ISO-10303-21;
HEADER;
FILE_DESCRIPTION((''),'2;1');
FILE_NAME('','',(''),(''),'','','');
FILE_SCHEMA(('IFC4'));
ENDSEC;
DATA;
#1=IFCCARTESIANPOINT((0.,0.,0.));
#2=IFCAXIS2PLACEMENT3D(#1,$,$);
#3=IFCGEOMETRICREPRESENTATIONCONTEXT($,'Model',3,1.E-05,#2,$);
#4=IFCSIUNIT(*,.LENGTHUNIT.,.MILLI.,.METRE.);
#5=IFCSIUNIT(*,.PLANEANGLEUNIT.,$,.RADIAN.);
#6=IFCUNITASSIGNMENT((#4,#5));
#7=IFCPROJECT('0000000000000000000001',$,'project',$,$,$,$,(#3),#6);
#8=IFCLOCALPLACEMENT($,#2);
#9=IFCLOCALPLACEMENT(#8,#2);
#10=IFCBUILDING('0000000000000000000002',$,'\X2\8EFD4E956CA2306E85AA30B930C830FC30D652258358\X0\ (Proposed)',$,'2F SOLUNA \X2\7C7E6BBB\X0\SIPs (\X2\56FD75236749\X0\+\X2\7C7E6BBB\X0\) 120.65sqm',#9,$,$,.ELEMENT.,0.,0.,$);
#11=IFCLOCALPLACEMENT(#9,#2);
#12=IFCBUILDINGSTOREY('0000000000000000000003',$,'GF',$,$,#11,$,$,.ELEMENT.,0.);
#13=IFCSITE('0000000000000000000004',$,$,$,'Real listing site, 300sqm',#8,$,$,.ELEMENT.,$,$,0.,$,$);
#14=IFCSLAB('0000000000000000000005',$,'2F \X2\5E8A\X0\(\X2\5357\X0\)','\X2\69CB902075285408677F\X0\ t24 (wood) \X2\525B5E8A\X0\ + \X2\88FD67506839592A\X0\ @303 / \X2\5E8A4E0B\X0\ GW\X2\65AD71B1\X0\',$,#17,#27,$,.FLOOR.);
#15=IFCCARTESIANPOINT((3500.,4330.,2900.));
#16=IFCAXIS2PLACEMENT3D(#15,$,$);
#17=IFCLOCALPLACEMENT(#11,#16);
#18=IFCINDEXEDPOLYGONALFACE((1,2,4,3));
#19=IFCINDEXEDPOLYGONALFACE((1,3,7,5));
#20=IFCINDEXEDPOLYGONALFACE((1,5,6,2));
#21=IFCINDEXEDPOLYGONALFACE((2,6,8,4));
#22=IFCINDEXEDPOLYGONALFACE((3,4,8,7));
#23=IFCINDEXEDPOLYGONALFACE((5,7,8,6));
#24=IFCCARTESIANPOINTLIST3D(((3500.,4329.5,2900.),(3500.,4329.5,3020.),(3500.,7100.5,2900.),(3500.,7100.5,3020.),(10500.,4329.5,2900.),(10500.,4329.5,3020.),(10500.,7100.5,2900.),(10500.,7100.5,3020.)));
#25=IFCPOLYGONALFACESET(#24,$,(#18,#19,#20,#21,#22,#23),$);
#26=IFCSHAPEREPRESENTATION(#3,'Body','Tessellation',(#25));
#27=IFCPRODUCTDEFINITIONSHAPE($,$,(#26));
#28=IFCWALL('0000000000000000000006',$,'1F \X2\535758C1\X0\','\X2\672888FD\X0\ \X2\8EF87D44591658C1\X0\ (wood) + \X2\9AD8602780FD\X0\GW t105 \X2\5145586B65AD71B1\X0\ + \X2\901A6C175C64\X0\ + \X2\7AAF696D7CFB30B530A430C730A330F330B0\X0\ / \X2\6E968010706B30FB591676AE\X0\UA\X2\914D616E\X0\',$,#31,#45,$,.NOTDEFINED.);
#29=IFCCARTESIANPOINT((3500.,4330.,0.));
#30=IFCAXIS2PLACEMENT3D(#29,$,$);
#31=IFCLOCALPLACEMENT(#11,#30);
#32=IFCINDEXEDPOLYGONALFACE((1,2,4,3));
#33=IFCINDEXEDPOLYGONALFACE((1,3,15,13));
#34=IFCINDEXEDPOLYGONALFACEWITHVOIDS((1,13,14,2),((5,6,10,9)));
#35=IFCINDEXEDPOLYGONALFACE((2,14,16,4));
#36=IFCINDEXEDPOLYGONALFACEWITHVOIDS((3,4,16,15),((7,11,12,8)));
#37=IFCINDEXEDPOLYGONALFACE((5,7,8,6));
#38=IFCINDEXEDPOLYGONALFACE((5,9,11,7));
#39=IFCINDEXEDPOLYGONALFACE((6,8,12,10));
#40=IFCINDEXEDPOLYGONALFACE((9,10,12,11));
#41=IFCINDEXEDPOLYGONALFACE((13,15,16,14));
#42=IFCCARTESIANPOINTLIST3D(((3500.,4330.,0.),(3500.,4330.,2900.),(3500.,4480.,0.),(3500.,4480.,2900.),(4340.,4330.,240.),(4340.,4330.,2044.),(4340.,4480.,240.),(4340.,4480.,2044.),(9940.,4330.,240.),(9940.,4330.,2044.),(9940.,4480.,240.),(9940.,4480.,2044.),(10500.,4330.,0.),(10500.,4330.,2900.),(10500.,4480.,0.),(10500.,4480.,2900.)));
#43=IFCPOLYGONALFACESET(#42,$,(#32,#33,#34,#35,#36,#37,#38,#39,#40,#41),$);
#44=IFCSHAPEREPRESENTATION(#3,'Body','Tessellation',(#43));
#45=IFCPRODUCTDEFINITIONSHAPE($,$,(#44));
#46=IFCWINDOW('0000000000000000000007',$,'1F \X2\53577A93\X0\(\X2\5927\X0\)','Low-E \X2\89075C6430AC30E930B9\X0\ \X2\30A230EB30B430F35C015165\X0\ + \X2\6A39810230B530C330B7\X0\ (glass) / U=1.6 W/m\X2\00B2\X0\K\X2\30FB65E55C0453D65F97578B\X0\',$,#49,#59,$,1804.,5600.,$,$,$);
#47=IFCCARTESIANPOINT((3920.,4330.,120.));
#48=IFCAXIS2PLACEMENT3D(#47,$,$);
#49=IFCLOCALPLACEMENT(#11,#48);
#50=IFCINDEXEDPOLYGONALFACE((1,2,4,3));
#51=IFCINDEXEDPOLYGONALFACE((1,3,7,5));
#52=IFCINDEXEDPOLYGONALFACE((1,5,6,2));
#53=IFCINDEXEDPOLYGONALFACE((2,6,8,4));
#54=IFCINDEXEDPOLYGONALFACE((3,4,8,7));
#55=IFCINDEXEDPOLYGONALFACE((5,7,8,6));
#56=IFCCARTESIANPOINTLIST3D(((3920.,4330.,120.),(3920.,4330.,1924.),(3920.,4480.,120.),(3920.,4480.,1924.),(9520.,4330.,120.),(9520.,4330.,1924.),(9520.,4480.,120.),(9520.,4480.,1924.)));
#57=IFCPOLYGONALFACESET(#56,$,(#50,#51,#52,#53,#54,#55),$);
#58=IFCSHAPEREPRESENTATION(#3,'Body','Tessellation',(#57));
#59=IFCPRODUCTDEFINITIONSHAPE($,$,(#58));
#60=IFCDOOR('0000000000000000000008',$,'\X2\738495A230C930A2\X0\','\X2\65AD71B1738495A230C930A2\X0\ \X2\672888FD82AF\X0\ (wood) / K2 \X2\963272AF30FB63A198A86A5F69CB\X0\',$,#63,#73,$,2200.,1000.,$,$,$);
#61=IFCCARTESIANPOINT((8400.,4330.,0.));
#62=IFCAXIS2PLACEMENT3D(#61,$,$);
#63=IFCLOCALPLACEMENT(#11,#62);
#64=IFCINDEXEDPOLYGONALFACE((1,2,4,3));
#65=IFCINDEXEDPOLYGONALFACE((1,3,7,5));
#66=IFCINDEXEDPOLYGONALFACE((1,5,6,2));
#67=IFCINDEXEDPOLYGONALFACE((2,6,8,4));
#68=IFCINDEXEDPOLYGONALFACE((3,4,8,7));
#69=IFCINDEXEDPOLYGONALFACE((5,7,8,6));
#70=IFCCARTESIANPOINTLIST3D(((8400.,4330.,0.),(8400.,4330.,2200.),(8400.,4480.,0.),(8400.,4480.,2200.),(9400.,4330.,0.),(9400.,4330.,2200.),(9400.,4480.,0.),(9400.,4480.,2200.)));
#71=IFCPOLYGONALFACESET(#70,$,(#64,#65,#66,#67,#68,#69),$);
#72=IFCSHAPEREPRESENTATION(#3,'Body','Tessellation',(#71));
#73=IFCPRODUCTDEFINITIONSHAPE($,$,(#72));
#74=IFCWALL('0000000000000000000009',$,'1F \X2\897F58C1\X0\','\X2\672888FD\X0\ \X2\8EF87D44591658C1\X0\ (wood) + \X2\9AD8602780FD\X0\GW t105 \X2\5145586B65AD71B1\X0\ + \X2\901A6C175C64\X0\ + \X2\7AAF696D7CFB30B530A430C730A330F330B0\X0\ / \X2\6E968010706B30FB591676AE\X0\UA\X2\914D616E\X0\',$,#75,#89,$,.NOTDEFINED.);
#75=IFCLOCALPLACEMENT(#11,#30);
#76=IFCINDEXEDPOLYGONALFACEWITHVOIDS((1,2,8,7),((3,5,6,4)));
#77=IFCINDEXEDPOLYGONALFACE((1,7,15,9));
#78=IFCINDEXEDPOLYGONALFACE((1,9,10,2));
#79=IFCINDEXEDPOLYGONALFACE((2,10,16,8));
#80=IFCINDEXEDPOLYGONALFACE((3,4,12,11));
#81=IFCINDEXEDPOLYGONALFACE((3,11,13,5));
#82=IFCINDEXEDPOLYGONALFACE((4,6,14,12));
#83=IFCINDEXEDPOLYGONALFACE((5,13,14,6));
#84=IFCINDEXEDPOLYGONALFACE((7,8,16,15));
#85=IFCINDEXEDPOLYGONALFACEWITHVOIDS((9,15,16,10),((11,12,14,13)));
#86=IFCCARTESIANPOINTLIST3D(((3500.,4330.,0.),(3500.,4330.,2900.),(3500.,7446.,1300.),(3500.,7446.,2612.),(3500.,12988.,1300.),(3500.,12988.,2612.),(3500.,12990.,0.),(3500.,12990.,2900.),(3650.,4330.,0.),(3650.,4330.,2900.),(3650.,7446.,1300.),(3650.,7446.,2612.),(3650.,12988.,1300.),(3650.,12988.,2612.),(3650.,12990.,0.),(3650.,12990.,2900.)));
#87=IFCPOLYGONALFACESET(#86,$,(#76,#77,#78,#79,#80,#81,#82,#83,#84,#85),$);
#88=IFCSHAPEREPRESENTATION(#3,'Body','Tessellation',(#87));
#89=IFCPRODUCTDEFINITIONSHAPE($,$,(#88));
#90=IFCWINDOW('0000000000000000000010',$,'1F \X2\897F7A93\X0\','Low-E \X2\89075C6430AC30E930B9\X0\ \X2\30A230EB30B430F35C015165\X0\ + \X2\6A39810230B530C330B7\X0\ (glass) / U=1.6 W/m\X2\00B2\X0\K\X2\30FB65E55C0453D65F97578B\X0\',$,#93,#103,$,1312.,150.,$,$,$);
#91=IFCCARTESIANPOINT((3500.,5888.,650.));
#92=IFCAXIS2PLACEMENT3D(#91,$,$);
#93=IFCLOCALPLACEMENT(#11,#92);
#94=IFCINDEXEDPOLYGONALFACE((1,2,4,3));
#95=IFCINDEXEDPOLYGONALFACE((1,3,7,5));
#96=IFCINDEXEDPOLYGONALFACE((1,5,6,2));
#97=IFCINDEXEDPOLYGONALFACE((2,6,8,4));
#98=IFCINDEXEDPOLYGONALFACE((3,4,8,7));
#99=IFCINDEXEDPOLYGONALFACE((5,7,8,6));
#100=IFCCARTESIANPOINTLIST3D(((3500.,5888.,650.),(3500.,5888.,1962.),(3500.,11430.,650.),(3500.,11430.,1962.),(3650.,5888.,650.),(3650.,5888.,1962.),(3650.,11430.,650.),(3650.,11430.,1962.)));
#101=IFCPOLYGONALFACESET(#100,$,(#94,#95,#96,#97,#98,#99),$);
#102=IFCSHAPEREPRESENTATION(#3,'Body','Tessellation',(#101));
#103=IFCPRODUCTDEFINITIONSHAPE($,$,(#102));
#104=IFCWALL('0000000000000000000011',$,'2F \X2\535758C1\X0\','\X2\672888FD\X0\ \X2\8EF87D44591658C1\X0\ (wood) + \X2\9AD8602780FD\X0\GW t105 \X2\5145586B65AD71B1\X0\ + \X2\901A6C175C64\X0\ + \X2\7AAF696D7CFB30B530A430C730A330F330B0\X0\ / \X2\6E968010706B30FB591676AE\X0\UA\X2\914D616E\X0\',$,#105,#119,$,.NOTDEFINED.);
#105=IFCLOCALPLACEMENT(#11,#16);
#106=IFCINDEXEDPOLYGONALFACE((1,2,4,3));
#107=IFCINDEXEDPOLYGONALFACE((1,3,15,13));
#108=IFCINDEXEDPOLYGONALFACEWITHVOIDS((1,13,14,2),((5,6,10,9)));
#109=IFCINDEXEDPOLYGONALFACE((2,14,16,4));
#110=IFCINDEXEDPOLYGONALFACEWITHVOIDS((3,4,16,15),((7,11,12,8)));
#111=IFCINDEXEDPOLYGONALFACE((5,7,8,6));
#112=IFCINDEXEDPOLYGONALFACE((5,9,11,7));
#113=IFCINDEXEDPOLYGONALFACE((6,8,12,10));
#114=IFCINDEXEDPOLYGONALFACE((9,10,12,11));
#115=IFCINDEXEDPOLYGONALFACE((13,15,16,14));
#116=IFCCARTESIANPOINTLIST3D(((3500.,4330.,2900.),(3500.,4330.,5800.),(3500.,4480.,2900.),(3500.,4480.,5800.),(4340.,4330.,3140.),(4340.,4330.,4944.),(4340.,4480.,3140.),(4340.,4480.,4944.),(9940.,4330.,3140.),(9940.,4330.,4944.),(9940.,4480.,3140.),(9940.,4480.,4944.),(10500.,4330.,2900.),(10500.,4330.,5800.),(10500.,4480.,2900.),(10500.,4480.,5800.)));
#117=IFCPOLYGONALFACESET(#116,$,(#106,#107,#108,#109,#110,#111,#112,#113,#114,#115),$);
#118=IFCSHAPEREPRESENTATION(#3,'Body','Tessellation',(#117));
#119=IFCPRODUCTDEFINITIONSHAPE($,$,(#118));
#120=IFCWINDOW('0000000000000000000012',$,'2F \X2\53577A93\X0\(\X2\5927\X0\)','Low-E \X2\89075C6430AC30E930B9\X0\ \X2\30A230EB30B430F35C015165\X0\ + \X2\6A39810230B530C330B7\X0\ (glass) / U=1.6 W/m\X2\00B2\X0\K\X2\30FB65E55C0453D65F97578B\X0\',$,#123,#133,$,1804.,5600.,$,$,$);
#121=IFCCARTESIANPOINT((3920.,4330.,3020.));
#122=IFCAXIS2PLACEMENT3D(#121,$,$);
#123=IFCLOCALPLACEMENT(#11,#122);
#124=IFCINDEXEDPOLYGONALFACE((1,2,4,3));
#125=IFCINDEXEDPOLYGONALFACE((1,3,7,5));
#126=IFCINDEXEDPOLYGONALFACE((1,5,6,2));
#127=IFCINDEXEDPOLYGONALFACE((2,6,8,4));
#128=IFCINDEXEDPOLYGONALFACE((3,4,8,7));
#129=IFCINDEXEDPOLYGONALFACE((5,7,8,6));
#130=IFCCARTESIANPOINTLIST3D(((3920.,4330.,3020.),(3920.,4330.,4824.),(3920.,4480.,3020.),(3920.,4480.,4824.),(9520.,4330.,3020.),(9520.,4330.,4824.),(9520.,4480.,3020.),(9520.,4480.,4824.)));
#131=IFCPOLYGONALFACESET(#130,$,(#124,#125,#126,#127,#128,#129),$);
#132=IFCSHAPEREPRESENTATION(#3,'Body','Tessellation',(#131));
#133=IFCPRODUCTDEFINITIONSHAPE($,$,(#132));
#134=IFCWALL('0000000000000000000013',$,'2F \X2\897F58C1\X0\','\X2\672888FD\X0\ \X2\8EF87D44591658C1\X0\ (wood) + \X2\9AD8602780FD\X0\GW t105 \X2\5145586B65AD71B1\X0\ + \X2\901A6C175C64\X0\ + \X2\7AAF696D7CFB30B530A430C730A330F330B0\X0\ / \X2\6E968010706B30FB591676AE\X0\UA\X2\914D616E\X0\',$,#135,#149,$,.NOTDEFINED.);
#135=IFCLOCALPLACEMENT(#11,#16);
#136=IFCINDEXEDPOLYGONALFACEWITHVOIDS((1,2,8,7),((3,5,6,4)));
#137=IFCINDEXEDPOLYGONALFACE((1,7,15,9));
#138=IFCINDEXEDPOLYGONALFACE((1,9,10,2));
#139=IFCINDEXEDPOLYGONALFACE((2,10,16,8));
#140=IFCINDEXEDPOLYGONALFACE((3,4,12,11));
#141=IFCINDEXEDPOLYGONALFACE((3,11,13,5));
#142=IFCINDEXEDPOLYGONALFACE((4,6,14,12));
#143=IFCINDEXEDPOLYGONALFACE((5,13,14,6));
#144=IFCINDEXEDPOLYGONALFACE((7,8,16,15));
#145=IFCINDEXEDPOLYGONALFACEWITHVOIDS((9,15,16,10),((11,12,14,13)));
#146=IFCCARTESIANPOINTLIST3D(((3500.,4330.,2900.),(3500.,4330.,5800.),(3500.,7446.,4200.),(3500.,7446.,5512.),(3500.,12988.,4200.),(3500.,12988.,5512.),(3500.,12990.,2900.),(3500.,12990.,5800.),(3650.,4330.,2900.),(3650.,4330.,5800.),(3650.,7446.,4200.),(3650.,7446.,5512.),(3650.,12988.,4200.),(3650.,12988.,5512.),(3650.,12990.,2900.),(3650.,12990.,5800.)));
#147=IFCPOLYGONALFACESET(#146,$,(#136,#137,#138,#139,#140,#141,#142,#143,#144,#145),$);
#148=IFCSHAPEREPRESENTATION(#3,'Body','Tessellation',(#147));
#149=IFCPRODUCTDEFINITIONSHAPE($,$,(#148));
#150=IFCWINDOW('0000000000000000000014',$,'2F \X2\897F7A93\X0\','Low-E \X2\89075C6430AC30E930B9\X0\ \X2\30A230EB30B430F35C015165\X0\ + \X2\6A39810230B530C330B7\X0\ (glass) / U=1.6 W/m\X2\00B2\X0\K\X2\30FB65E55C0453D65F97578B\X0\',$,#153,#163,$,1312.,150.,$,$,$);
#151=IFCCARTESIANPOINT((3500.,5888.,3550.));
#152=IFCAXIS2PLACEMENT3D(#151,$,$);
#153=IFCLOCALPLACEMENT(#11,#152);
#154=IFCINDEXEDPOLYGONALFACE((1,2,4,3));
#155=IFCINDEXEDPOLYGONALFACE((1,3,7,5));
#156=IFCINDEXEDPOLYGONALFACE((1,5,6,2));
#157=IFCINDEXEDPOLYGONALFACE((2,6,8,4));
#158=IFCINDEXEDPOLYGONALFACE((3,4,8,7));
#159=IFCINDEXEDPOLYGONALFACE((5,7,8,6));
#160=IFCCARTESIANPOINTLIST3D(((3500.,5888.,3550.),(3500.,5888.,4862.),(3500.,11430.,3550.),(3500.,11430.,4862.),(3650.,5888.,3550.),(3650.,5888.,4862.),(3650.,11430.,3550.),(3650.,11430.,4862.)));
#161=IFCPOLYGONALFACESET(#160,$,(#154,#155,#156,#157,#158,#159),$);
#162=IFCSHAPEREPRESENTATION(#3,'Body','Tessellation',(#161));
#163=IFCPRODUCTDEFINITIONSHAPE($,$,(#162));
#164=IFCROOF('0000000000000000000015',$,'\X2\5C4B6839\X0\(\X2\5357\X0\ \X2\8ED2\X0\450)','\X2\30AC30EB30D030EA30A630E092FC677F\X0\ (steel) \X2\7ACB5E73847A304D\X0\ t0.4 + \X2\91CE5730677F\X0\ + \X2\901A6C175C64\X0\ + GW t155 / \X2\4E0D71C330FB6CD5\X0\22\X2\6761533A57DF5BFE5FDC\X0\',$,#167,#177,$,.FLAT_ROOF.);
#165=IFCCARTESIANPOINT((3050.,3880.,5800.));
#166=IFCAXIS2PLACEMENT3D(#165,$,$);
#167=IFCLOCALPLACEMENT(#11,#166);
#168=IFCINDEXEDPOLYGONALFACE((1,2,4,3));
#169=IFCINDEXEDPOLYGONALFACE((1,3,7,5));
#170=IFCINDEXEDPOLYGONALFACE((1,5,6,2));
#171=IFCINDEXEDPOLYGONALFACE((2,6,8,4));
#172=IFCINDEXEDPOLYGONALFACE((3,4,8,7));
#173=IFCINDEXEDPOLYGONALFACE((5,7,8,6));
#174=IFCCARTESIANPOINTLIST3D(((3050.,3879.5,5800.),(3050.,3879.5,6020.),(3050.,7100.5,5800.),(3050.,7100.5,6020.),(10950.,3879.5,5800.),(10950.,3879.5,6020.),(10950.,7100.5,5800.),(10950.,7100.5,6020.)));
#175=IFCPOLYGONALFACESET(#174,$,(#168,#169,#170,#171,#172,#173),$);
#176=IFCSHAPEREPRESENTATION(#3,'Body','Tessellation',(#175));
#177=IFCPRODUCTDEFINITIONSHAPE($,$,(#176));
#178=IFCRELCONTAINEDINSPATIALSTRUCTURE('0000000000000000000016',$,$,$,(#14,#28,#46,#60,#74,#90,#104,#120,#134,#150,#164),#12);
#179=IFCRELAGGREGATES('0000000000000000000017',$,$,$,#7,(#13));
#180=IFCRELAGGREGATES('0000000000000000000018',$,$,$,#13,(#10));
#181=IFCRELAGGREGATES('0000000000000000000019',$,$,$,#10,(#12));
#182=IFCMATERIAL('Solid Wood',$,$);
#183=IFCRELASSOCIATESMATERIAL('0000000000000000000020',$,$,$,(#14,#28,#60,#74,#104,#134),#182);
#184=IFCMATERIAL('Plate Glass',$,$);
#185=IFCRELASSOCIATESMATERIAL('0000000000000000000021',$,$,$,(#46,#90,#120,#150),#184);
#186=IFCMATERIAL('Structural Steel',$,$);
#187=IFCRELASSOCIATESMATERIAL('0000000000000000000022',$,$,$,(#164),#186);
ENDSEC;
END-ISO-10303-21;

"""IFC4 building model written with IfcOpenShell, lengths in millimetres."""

from ifc_helpers import new_model, si_unit, frame, frame_2d, origin, place, context, project, spatial, rectangle, extrude, material, element, fill, save


model = new_model("IFC4")

# Units and contexts
model_context = context("Model", 3, precision=1e-05, world=origin())
ifc_project = project(units=[si_unit("LENGTHUNIT", "METRE", prefix="MILLI"), si_unit("PLANEANGLEUNIT", "RADIAN")], contexts=[model_context])

# Site, building, storey
site_placement = place(None, origin())
site = spatial("IfcSite", under=ifc_project, at=site_placement, ObjectType="Real listing site, 300sqm", CompositionType="ELEMENT", RefElevation=0.0)
building_placement = place(site_placement, origin())
building = spatial("IfcBuilding", under=site, at=building_placement, Name="軽井沢の薪ストーブ別荘 (Proposed)", ObjectType="2F SOLUNA 籾殻SIPs (国産杉+籾殻) 120.65sqm", CompositionType="ELEMENT", ElevationOfRefHeight=0.0, ElevationOfTerrain=0.0)
storey_placement = place(building_placement, origin())
storey = spatial("IfcBuildingStorey", under=building, at=storey_placement, Name="GF", CompositionType="ELEMENT", Elevation=0.0)

# Slab
ifc_material_1 = material(Name="Solid Wood")
slab_1_placement = place(storey_placement, frame((3500.0, 4330.0, 2900.0)))
element("IfcSlab", 1, at=slab_1_placement, inside=storey, material=ifc_material_1, Name="2F 床(南)", Description="構造用合板 t24 (wood) 剛床 + 製材根太 @303 / 床下 GW断熱", PredefinedType="FLOOR", context=model_context, shape_type="SweptSolid", body=[
    extrude(rectangle(XDim=7000.0, YDim=2771.0, at=frame_2d((3500.0, 1385.0))), frame((3500.0, 4330.0, 2900.0)), (0.0, 0.0, 1.0), 120.0),
])

# Wall, openings, window, door
wall_1_placement = place(storey_placement, frame((3500.0, 4330.0, 0.0)))
wall_1 = element("IfcWall", 2, at=wall_1_placement, inside=storey, material=ifc_material_1, Name="1F 南壁", Description="木製 軸組外壁 (wood) + 高性能GW t105 充填断熱 + 通気層 + 窯業系サイディング / 準耐火・外皮UA配慮", PredefinedType="NOTDEFINED", context=model_context, shape_type="SweptSolid", body=[
    extrude(rectangle(XDim=7000.0, YDim=150.0, at=frame_2d((3500.0, 75.0))), frame((3500.0, 4330.0, 0.0)), (0.0, 0.0, 1.0), 2900.0),
])
opening_1_placement = place(storey_placement, frame((3920.0, 4330.0, 120.0)))
opening_1 = element("IfcOpeningElement", 3, at=opening_1_placement, cuts=wall_1, PredefinedType="NOTDEFINED", context=model_context, shape_type="SweptSolid", body=[
    extrude(rectangle(XDim=5600.0, YDim=150.0, at=frame_2d((2800.0, 75.0))), frame((3920.0, 4330.0, 120.0)), (0.0, 0.0, 1.0), 1804.0),
])
opening_2_placement = place(storey_placement, frame((8400.0, 4330.0, 0.0)))
opening_2 = element("IfcOpeningElement", 4, at=opening_2_placement, cuts=wall_1, PredefinedType="NOTDEFINED", context=model_context, shape_type="SweptSolid", body=[
    extrude(rectangle(XDim=1000.0, YDim=150.0, at=frame_2d((500.0, 75.0))), frame((8400.0, 4330.0, 0.0)), (0.0, 0.0, 1.0), 2200.0),
])
ifc_material_2 = material(Name="Plate Glass")
window_1_placement = place(storey_placement, frame((3920.0, 4330.0, 120.0)))
window_1 = element("IfcWindow", 5, at=window_1_placement, inside=storey, material=ifc_material_2, Name="1F 南窓(大)", Description="Low-E 複層ガラス アルゴン封入 + 樹脂サッシ (glass) / U=1.6 W/m²K・日射取得型", OverallHeight=1804.0, OverallWidth=5600.0, context=model_context, shape_type="SweptSolid", body=[
    extrude(rectangle(XDim=5600.0, YDim=150.0, at=frame_2d((2800.0, 75.0))), frame((3920.0, 4330.0, 120.0)), (0.0, 0.0, 1.0), 1804.0),
])
fill(opening_1, window_1)
door_placement = place(storey_placement, frame((8400.0, 4330.0, 0.0)))
door = element("IfcDoor", 6, at=door_placement, inside=storey, material=ifc_material_1, Name="玄関ドア", Description="断熱玄関ドア 木製芯 (wood) / K2 防犯・採風機構", OverallHeight=2200.0, OverallWidth=1000.0, context=model_context, shape_type="SweptSolid", body=[
    extrude(rectangle(XDim=1000.0, YDim=150.0, at=frame_2d((500.0, 75.0))), frame((8400.0, 4330.0, 0.0)), (0.0, 0.0, 1.0), 2200.0),
])
fill(opening_2, door)

# Walls, openings, windows
wall_2_placement = place(storey_placement, frame((3500.0, 4330.0, 0.0)))
wall_2 = element("IfcWall", 7, at=wall_2_placement, inside=storey, material=ifc_material_1, Name="1F 西壁", Description="木製 軸組外壁 (wood) + 高性能GW t105 充填断熱 + 通気層 + 窯業系サイディング / 準耐火・外皮UA配慮", PredefinedType="NOTDEFINED", context=model_context, shape_type="SweptSolid", body=[
    extrude(rectangle(XDim=150.0, YDim=8660.0, at=frame_2d((75.0, 4330.0))), frame((3500.0, 4330.0, 0.0)), (0.0, 0.0, 1.0), 2900.0),
])
opening_3_placement = place(storey_placement, frame((3500.0, 5888.0, 650.0)))
opening_3 = element("IfcOpeningElement", 8, at=opening_3_placement, cuts=wall_2, PredefinedType="NOTDEFINED", context=model_context, shape_type="SweptSolid", body=[
    extrude(rectangle(XDim=150.0, YDim=5542.0, at=frame_2d((75.0, 2771.0))), frame((3500.0, 5888.0, 650.0)), (0.0, 0.0, 1.0), 1312.0),
])
window_2_placement = place(storey_placement, frame((3500.0, 5888.0, 650.0)))
window_2 = element("IfcWindow", 9, at=window_2_placement, inside=storey, material=ifc_material_2, Name="1F 西窓", Description="Low-E 複層ガラス アルゴン封入 + 樹脂サッシ (glass) / U=1.6 W/m²K・日射取得型", OverallHeight=1312.0, OverallWidth=150.0, context=model_context, shape_type="SweptSolid", body=[
    extrude(rectangle(XDim=150.0, YDim=5542.0, at=frame_2d((75.0, 2771.0))), frame((3500.0, 5888.0, 650.0)), (0.0, 0.0, 1.0), 1312.0),
])
fill(opening_3, window_2)
wall_3_placement = place(storey_placement, frame((3500.0, 4330.0, 2900.0)))
wall_3 = element("IfcWall", 10, at=wall_3_placement, inside=storey, material=ifc_material_1, Name="2F 南壁", Description="木製 軸組外壁 (wood) + 高性能GW t105 充填断熱 + 通気層 + 窯業系サイディング / 準耐火・外皮UA配慮", PredefinedType="NOTDEFINED", context=model_context, shape_type="SweptSolid", body=[
    extrude(rectangle(XDim=7000.0, YDim=150.0, at=frame_2d((3500.0, 75.0))), frame((3500.0, 4330.0, 2900.0)), (0.0, 0.0, 1.0), 2900.0),
])
opening_4_placement = place(storey_placement, frame((3920.0, 4330.0, 3020.0)))
opening_4 = element("IfcOpeningElement", 11, at=opening_4_placement, cuts=wall_3, PredefinedType="NOTDEFINED", context=model_context, shape_type="SweptSolid", body=[
    extrude(rectangle(XDim=5600.0, YDim=150.0, at=frame_2d((2800.0, 75.0))), frame((3920.0, 4330.0, 3020.0)), (0.0, 0.0, 1.0), 1804.0),
])
window_3_placement = place(storey_placement, frame((3920.0, 4330.0, 3020.0)))
window_3 = element("IfcWindow", 12, at=window_3_placement, inside=storey, material=ifc_material_2, Name="2F 南窓(大)", Description="Low-E 複層ガラス アルゴン封入 + 樹脂サッシ (glass) / U=1.6 W/m²K・日射取得型", OverallHeight=1804.0, OverallWidth=5600.0, context=model_context, shape_type="SweptSolid", body=[
    extrude(rectangle(XDim=5600.0, YDim=150.0, at=frame_2d((2800.0, 75.0))), frame((3920.0, 4330.0, 3020.0)), (0.0, 0.0, 1.0), 1804.0),
])
fill(opening_4, window_3)
wall_4_placement = place(storey_placement, frame((3500.0, 4330.0, 2900.0)))
wall_4 = element("IfcWall", 13, at=wall_4_placement, inside=storey, material=ifc_material_1, Name="2F 西壁", Description="木製 軸組外壁 (wood) + 高性能GW t105 充填断熱 + 通気層 + 窯業系サイディング / 準耐火・外皮UA配慮", PredefinedType="NOTDEFINED", context=model_context, shape_type="SweptSolid", body=[
    extrude(rectangle(XDim=150.0, YDim=8660.0, at=frame_2d((75.0, 4330.0))), frame((3500.0, 4330.0, 2900.0)), (0.0, 0.0, 1.0), 2900.0),
])
opening_5_placement = place(storey_placement, frame((3500.0, 5888.0, 3550.0)))
opening_5 = element("IfcOpeningElement", 14, at=opening_5_placement, cuts=wall_4, PredefinedType="NOTDEFINED", context=model_context, shape_type="SweptSolid", body=[
    extrude(rectangle(XDim=150.0, YDim=5542.0, at=frame_2d((75.0, 2771.0))), frame((3500.0, 5888.0, 3550.0)), (0.0, 0.0, 1.0), 1312.0),
])
window_4_placement = place(storey_placement, frame((3500.0, 5888.0, 3550.0)))
window_4 = element("IfcWindow", 15, at=window_4_placement, inside=storey, material=ifc_material_2, Name="2F 西窓", Description="Low-E 複層ガラス アルゴン封入 + 樹脂サッシ (glass) / U=1.6 W/m²K・日射取得型", OverallHeight=1312.0, OverallWidth=150.0, context=model_context, shape_type="SweptSolid", body=[
    extrude(rectangle(XDim=150.0, YDim=5542.0, at=frame_2d((75.0, 2771.0))), frame((3500.0, 5888.0, 3550.0)), (0.0, 0.0, 1.0), 1312.0),
])
fill(opening_5, window_4)

# Roof
ifc_material_3 = material(Name="Structural Steel")
roof_1_placement = place(storey_placement, frame((3050.0, 3880.0, 5800.0)))
element("IfcRoof", 16, at=roof_1_placement, inside=storey, material=ifc_material_3, Name="屋根(南 軒450)", Description="ガルバリウム鋼板 (steel) 立平葺き t0.4 + 野地板 + 通気層 + GW t155 / 不燃・法22条区域対応", PredefinedType="FLAT_ROOF", context=model_context, shape_type="SweptSolid", body=[
    extrude(rectangle(XDim=7900.0, YDim=3221.0, at=frame_2d((3950.0, 1610.0))), frame((3050.0, 3880.0, 5800.0)), (0.0, 0.0, 1.0), 220.0),
])

save(model, "model.ifc")
